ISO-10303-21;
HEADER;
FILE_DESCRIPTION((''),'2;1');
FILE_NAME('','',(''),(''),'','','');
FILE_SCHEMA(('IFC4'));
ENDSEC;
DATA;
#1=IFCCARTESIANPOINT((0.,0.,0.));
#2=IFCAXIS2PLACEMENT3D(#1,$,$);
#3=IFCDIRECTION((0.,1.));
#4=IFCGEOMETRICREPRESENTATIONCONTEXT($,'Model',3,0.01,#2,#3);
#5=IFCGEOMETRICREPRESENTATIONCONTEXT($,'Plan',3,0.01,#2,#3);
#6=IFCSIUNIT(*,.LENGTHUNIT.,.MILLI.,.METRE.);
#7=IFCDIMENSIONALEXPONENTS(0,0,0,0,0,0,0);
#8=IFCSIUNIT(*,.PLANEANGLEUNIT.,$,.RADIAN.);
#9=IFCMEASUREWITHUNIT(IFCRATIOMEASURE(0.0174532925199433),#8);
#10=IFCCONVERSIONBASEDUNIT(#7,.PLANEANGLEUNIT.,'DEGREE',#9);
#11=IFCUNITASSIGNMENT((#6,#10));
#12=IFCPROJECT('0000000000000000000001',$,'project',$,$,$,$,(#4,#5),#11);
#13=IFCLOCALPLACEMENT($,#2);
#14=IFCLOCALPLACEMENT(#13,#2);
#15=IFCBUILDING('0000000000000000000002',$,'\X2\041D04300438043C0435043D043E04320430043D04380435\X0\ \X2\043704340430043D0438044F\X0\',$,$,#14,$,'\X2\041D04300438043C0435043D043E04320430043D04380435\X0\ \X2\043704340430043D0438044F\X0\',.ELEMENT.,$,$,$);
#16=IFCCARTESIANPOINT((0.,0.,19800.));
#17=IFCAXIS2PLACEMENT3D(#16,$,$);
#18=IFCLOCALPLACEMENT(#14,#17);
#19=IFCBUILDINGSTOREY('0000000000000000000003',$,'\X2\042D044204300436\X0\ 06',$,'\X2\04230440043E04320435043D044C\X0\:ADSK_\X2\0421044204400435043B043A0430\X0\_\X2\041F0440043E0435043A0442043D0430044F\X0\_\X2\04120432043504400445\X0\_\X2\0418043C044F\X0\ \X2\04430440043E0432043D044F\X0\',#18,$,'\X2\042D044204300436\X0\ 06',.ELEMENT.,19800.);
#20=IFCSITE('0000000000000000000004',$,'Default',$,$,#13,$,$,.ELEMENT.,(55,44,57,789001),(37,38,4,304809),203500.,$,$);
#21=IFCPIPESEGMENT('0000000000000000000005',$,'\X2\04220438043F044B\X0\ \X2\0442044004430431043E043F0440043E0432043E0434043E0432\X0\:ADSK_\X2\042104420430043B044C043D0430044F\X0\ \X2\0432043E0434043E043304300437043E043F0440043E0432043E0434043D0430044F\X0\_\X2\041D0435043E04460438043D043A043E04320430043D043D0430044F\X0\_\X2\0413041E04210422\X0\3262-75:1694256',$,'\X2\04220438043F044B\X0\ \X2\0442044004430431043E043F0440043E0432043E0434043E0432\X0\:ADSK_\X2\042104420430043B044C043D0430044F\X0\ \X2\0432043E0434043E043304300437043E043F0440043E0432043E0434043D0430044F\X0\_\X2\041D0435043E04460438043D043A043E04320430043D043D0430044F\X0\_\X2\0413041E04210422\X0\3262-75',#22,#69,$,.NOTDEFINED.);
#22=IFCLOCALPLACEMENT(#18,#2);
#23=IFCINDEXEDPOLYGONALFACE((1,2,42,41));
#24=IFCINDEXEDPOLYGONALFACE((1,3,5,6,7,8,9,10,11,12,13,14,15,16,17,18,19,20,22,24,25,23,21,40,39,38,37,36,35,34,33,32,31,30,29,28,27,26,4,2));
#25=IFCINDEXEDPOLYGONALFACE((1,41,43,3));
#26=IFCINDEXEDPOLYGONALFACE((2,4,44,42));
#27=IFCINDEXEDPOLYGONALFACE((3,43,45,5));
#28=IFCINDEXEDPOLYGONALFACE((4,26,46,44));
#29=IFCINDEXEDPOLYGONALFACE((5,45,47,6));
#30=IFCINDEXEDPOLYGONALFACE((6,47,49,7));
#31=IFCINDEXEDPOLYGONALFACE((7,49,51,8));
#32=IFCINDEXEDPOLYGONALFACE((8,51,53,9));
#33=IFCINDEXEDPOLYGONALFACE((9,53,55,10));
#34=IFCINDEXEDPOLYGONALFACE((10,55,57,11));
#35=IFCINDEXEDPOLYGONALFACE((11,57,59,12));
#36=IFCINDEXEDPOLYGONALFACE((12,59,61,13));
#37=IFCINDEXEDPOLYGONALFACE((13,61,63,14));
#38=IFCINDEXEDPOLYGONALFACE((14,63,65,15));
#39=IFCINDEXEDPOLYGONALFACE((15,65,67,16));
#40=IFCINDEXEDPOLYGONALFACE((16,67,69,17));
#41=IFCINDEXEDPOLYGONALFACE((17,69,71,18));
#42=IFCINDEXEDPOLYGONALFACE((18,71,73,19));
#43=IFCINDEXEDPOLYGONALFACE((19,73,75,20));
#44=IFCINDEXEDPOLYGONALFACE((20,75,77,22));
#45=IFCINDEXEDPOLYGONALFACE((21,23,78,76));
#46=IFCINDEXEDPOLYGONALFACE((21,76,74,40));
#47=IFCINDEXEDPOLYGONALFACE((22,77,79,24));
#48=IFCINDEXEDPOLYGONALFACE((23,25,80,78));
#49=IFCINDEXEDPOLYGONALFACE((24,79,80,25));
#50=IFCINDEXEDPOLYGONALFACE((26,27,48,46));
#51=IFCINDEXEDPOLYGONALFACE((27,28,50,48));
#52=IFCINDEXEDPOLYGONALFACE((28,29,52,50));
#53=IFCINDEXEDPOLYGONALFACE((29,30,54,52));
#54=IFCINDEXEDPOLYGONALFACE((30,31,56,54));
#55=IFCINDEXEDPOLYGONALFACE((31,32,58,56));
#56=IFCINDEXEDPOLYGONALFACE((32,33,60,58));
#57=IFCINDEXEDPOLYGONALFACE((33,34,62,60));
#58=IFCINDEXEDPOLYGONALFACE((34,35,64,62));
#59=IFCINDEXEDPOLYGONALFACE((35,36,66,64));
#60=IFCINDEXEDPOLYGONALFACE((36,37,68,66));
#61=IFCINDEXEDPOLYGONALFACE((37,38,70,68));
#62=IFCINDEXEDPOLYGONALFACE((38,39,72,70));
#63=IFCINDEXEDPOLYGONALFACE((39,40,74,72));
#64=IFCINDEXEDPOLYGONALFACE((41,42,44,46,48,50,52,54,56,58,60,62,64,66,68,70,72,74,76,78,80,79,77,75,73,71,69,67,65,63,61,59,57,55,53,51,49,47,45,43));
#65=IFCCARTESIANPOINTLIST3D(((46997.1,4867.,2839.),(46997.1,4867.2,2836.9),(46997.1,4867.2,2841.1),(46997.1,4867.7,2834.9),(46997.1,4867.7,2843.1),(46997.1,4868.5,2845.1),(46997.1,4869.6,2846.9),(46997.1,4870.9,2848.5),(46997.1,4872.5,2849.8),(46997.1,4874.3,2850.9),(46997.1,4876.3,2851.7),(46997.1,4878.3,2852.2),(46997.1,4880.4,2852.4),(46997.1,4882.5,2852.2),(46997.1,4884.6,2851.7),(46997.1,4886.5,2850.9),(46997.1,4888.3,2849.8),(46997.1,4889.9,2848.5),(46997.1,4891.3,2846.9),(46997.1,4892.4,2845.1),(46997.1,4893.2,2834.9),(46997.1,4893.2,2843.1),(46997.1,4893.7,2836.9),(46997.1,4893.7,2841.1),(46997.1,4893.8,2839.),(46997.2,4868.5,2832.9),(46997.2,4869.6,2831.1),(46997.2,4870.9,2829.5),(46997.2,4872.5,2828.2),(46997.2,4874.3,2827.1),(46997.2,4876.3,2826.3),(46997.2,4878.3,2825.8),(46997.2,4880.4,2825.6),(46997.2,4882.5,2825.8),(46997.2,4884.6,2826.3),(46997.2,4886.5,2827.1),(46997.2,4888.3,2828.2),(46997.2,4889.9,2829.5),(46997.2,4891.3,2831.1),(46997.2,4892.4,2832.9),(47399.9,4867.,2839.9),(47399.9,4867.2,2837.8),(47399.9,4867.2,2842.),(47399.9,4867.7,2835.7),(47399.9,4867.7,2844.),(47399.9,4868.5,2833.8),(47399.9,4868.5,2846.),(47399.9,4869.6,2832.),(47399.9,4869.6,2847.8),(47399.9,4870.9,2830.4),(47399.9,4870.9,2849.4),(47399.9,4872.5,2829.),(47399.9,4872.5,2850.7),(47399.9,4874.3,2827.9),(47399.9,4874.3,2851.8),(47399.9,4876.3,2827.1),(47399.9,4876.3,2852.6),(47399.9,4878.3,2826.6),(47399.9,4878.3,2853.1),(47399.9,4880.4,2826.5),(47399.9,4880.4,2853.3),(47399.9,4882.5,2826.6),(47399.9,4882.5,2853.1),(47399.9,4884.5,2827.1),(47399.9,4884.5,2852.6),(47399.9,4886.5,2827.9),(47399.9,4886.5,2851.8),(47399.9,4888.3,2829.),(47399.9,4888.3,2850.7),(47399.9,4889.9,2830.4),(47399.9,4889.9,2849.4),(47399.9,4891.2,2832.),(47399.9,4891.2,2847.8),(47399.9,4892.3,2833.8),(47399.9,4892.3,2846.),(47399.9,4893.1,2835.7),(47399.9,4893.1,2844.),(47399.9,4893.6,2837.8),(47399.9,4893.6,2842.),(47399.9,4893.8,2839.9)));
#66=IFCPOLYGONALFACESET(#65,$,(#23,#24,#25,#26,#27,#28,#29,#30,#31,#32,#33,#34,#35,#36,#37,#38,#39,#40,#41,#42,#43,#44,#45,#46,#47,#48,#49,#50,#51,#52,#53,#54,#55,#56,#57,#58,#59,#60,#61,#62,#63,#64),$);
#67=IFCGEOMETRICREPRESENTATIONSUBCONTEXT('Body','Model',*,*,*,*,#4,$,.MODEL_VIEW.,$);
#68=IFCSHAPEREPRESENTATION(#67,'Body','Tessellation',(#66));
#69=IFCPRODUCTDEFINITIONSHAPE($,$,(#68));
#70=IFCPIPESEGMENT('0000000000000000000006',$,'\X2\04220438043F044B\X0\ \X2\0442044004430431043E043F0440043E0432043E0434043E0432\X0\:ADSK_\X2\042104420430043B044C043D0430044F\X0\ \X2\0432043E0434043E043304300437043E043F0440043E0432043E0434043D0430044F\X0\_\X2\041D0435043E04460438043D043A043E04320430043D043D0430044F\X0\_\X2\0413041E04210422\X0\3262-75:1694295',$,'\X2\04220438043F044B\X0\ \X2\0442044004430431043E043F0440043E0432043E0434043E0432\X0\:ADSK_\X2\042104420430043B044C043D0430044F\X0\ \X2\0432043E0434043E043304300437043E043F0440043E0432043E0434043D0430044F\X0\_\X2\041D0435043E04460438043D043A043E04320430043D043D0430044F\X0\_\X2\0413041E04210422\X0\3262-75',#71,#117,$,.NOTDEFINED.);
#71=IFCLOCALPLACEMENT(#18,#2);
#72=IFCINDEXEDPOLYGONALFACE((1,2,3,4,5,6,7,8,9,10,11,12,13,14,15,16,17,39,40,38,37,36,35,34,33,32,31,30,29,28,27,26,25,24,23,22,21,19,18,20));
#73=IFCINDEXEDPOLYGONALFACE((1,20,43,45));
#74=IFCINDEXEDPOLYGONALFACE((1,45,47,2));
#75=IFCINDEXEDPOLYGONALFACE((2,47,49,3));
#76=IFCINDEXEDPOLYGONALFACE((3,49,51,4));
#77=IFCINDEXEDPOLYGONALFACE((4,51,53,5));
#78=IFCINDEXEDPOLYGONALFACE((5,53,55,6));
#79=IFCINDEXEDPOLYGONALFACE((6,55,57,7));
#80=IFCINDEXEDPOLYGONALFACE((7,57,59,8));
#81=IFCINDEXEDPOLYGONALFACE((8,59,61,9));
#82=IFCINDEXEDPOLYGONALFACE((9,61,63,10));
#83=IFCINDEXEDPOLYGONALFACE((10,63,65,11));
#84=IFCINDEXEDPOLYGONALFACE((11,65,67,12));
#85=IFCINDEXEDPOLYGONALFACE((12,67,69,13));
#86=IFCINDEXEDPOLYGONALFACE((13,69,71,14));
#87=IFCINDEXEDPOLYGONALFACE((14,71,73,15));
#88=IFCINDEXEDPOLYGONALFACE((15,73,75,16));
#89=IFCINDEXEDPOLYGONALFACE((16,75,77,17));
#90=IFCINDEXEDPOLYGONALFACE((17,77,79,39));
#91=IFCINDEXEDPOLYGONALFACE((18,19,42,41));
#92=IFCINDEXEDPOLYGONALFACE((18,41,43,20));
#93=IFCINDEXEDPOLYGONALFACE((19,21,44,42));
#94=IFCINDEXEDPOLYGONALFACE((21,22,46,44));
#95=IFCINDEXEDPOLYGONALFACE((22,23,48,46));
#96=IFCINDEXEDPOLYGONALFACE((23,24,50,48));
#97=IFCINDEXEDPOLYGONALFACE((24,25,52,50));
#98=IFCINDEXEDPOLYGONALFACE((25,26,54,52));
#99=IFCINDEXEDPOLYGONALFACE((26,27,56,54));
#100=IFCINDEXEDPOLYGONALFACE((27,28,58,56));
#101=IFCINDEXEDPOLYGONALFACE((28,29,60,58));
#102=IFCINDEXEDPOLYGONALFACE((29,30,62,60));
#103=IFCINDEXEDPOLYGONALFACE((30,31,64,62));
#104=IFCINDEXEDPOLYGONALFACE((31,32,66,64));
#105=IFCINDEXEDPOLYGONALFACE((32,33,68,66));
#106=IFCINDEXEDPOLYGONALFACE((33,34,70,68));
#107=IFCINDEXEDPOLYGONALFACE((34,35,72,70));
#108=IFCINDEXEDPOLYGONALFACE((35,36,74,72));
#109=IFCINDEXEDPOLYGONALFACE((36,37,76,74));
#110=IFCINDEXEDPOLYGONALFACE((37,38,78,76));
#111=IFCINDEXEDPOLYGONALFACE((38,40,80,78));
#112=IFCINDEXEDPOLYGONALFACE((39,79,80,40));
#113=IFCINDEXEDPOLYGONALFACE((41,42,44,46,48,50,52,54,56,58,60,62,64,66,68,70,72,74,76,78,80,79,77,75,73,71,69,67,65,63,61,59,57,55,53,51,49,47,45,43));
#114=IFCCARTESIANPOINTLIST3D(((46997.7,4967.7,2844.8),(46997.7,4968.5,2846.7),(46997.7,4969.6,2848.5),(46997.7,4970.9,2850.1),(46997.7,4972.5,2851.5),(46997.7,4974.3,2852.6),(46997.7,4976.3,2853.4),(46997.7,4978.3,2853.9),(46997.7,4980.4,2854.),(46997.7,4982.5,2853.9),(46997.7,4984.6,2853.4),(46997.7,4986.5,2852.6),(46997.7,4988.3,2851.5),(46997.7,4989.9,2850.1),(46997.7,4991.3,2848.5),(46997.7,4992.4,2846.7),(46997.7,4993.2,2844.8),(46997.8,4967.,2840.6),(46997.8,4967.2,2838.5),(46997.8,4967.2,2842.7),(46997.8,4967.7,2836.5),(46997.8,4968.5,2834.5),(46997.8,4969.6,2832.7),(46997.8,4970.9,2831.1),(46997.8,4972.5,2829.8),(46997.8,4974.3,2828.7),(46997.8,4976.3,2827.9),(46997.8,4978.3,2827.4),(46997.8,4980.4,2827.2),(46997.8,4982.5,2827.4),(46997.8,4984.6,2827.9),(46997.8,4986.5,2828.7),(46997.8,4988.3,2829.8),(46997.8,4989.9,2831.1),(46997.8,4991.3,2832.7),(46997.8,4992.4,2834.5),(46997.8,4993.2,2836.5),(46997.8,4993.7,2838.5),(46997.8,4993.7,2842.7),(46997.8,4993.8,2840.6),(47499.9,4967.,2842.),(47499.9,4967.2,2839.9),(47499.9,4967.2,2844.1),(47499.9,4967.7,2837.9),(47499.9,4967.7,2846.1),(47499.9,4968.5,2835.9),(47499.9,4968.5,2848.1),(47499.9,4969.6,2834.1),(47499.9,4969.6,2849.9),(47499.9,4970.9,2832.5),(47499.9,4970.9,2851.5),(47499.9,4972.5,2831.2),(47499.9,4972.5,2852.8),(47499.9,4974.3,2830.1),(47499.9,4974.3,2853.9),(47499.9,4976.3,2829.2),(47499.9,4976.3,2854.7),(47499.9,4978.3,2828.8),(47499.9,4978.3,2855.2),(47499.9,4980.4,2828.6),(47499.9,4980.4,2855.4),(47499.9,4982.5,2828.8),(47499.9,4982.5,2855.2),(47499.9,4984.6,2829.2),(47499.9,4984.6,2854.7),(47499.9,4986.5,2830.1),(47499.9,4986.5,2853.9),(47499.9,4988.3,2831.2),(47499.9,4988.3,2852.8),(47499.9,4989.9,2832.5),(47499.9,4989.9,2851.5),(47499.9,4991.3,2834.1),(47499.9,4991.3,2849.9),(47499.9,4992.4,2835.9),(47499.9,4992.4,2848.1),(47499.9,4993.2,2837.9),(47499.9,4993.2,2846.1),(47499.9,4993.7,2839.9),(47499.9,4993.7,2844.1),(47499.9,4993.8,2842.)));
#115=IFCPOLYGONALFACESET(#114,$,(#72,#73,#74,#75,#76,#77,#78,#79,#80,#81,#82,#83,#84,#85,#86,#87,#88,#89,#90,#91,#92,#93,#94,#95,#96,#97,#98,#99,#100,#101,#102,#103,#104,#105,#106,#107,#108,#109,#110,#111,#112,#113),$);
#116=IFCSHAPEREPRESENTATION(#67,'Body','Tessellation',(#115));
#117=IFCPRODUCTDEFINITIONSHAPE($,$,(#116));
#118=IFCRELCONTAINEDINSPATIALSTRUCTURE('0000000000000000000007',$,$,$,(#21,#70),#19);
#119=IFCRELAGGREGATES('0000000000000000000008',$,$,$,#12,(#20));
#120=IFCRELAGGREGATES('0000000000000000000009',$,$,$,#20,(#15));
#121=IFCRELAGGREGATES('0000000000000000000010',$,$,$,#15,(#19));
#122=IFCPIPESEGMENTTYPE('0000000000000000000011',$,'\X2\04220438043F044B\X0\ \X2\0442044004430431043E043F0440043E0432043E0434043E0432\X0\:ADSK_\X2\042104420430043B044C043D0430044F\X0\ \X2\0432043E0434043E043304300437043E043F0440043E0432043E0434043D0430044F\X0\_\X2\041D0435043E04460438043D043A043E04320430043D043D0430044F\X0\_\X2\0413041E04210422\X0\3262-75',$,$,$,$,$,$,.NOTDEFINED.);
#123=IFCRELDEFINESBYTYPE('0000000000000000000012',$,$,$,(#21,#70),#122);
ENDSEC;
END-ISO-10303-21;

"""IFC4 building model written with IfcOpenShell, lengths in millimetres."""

from ifc_helpers import new_model, entity, si_unit, converted_unit, direction, frame, origin, place, context, subcontext, project, spatial, indexed_curve, outline, extrude, type_object, element, save


model = new_model("IFC4")

# Units and contexts
model_context = context("Model", 3, precision=0.01, world=origin(), true_north=direction((0.0, 1.0)))
plan_context = context("Plan", 3, precision=0.01, world=origin(), true_north=direction((0.0, 1.0)))
body_context = subcontext(model_context, "Body", "Model", "MODEL_VIEW")
ifc_project = project(units=[si_unit("LENGTHUNIT", "METRE", prefix="MILLI"), converted_unit("PLANEANGLEUNIT", "DEGREE", entity("IfcRatioMeasure", 0.0174532925199433), si_unit("PLANEANGLEUNIT", "RADIAN"), dimensions=[0, 0, 0, 0, 0, 0, 0])], contexts=[model_context, plan_context])

# Site, building, storey
site_placement = place(None, origin())
site = spatial("IfcSite", under=ifc_project, at=site_placement, Name="Default", CompositionType="ELEMENT", RefLatitude=(55, 44, 57, 789001), RefLongitude=(37, 38, 4, 304809), RefElevation=203500.0)
building_placement = place(site_placement, origin())
building = spatial("IfcBuilding", under=site, at=building_placement, Name="Наименование здания", LongName="Наименование здания", CompositionType="ELEMENT")
storey_placement = place(building_placement, frame((0.0, 0.0, 19800.0)))
storey = spatial("IfcBuildingStorey", under=building, at=storey_placement, Name="Этаж 06", ObjectType="Уровень:ADSK_Стрелка_Проектная_Вверх_Имя уровня", LongName="Этаж 06", CompositionType="ELEMENT", Elevation=19800.0)

# Pipe segments
pipe_segment_type = type_object("IfcPipeSegmentType", Name="Типы трубопроводов:ADSK_Стальная водогазопроводная_Неоцинкованная_ГОСТ3262-75", PredefinedType="NOTDEFINED")
placement = place(storey_placement, origin())
element("IfcPipeSegment", 1, at=placement, inside=storey, type_object=pipe_segment_type, Name="Типы трубопроводов:ADSK_Стальная водогазопроводная_Неоцинкованная_ГОСТ3262-75:1694256", ObjectType="Типы трубопроводов:ADSK_Стальная водогазопроводная_Неоцинкованная_ГОСТ3262-75", PredefinedType="NOTDEFINED", context=body_context, shape_type="SweptSolid", body=[
    extrude(outline(indexed_curve([(13.4, 0.0), (13.2, 2.1), (12.7, 4.1), (11.9, 6.1), (10.8, 7.9), (9.5, 9.5), (7.9, 10.8), (6.1, 11.9), (4.1, 12.7), (2.1, 13.2), (0.0, 13.4), (-2.1, 13.2), (-4.1, 12.7), (-6.1, 11.9), (-7.9, 10.8), (-9.5, 9.5), (-10.8, 7.9), (-11.9, 6.1), (-12.7, 4.1), (-13.2, 2.1), (-13.4, 0.0), (-13.2, -2.1), (-12.7, -4.1), (-11.9, -6.1), (-10.8, -7.9), (-9.5, -9.5), (-7.9, -10.8), (-6.1, -11.9), (-4.1, -12.7), (-2.1, -13.2), (0.0, -13.4), (2.1, -13.2), (4.1, -12.7), (6.1, -11.9), (7.9, -10.8), (9.5, -9.5), (10.8, -7.9), (11.9, -6.1), (12.7, -4.1), (13.2, -2.1), (13.4, 0.0)], self_intersect=False)), frame((46997.1, 4880.4, 2839.0), z_axis=(0.999998, -0.000044, 0.002187), x_axis=(0.000044, 1.0, 0.0)), (0.0, 0.0, 1.0), 402.8),
])
element("IfcPipeSegment", 2, at=placement, inside=storey, type_object=pipe_segment_type, Name="Типы трубопроводов:ADSK_Стальная водогазопроводная_Неоцинкованная_ГОСТ3262-75:1694295", ObjectType="Типы трубопроводов:ADSK_Стальная водогазопроводная_Неоцинкованная_ГОСТ3262-75", PredefinedType="NOTDEFINED", context=body_context, shape_type="SweptSolid", body=[
    extrude(outline(indexed_curve([(13.4, 0.0), (13.2, 2.1), (12.7, 4.1), (11.9, 6.1), (10.8, 7.9), (9.5, 9.5), (7.9, 10.8), (6.1, 11.9), (4.1, 12.7), (2.1, 13.2), (0.0, 13.4), (-2.1, 13.2), (-4.1, 12.7), (-6.1, 11.9), (-7.9, 10.8), (-9.5, 9.5), (-10.8, 7.9), (-11.9, 6.1), (-12.7, 4.1), (-13.2, 2.1), (-13.4, 0.0), (-13.2, -2.1), (-12.7, -4.1), (-11.9, -6.1), (-10.8, -7.9), (-9.5, -9.5), (-7.9, -10.8), (-6.1, -11.9), (-4.1, -12.7), (-2.1, -13.2), (0.0, -13.4), (2.1, -13.2), (4.1, -12.7), (6.1, -11.9), (7.9, -10.8), (9.5, -9.5), (10.8, -7.9), (11.9, -6.1), (12.7, -4.1), (13.2, -2.1), (13.4, 0.0)], self_intersect=False)), frame((46997.8, 4980.4, 2840.6), z_axis=(0.999996, 0.0, 0.002736), x_axis=(0.0, 1.0, 0.0)), (0.0, 0.0, 1.0), 502.1),
])

save(model, "model.ifc")
